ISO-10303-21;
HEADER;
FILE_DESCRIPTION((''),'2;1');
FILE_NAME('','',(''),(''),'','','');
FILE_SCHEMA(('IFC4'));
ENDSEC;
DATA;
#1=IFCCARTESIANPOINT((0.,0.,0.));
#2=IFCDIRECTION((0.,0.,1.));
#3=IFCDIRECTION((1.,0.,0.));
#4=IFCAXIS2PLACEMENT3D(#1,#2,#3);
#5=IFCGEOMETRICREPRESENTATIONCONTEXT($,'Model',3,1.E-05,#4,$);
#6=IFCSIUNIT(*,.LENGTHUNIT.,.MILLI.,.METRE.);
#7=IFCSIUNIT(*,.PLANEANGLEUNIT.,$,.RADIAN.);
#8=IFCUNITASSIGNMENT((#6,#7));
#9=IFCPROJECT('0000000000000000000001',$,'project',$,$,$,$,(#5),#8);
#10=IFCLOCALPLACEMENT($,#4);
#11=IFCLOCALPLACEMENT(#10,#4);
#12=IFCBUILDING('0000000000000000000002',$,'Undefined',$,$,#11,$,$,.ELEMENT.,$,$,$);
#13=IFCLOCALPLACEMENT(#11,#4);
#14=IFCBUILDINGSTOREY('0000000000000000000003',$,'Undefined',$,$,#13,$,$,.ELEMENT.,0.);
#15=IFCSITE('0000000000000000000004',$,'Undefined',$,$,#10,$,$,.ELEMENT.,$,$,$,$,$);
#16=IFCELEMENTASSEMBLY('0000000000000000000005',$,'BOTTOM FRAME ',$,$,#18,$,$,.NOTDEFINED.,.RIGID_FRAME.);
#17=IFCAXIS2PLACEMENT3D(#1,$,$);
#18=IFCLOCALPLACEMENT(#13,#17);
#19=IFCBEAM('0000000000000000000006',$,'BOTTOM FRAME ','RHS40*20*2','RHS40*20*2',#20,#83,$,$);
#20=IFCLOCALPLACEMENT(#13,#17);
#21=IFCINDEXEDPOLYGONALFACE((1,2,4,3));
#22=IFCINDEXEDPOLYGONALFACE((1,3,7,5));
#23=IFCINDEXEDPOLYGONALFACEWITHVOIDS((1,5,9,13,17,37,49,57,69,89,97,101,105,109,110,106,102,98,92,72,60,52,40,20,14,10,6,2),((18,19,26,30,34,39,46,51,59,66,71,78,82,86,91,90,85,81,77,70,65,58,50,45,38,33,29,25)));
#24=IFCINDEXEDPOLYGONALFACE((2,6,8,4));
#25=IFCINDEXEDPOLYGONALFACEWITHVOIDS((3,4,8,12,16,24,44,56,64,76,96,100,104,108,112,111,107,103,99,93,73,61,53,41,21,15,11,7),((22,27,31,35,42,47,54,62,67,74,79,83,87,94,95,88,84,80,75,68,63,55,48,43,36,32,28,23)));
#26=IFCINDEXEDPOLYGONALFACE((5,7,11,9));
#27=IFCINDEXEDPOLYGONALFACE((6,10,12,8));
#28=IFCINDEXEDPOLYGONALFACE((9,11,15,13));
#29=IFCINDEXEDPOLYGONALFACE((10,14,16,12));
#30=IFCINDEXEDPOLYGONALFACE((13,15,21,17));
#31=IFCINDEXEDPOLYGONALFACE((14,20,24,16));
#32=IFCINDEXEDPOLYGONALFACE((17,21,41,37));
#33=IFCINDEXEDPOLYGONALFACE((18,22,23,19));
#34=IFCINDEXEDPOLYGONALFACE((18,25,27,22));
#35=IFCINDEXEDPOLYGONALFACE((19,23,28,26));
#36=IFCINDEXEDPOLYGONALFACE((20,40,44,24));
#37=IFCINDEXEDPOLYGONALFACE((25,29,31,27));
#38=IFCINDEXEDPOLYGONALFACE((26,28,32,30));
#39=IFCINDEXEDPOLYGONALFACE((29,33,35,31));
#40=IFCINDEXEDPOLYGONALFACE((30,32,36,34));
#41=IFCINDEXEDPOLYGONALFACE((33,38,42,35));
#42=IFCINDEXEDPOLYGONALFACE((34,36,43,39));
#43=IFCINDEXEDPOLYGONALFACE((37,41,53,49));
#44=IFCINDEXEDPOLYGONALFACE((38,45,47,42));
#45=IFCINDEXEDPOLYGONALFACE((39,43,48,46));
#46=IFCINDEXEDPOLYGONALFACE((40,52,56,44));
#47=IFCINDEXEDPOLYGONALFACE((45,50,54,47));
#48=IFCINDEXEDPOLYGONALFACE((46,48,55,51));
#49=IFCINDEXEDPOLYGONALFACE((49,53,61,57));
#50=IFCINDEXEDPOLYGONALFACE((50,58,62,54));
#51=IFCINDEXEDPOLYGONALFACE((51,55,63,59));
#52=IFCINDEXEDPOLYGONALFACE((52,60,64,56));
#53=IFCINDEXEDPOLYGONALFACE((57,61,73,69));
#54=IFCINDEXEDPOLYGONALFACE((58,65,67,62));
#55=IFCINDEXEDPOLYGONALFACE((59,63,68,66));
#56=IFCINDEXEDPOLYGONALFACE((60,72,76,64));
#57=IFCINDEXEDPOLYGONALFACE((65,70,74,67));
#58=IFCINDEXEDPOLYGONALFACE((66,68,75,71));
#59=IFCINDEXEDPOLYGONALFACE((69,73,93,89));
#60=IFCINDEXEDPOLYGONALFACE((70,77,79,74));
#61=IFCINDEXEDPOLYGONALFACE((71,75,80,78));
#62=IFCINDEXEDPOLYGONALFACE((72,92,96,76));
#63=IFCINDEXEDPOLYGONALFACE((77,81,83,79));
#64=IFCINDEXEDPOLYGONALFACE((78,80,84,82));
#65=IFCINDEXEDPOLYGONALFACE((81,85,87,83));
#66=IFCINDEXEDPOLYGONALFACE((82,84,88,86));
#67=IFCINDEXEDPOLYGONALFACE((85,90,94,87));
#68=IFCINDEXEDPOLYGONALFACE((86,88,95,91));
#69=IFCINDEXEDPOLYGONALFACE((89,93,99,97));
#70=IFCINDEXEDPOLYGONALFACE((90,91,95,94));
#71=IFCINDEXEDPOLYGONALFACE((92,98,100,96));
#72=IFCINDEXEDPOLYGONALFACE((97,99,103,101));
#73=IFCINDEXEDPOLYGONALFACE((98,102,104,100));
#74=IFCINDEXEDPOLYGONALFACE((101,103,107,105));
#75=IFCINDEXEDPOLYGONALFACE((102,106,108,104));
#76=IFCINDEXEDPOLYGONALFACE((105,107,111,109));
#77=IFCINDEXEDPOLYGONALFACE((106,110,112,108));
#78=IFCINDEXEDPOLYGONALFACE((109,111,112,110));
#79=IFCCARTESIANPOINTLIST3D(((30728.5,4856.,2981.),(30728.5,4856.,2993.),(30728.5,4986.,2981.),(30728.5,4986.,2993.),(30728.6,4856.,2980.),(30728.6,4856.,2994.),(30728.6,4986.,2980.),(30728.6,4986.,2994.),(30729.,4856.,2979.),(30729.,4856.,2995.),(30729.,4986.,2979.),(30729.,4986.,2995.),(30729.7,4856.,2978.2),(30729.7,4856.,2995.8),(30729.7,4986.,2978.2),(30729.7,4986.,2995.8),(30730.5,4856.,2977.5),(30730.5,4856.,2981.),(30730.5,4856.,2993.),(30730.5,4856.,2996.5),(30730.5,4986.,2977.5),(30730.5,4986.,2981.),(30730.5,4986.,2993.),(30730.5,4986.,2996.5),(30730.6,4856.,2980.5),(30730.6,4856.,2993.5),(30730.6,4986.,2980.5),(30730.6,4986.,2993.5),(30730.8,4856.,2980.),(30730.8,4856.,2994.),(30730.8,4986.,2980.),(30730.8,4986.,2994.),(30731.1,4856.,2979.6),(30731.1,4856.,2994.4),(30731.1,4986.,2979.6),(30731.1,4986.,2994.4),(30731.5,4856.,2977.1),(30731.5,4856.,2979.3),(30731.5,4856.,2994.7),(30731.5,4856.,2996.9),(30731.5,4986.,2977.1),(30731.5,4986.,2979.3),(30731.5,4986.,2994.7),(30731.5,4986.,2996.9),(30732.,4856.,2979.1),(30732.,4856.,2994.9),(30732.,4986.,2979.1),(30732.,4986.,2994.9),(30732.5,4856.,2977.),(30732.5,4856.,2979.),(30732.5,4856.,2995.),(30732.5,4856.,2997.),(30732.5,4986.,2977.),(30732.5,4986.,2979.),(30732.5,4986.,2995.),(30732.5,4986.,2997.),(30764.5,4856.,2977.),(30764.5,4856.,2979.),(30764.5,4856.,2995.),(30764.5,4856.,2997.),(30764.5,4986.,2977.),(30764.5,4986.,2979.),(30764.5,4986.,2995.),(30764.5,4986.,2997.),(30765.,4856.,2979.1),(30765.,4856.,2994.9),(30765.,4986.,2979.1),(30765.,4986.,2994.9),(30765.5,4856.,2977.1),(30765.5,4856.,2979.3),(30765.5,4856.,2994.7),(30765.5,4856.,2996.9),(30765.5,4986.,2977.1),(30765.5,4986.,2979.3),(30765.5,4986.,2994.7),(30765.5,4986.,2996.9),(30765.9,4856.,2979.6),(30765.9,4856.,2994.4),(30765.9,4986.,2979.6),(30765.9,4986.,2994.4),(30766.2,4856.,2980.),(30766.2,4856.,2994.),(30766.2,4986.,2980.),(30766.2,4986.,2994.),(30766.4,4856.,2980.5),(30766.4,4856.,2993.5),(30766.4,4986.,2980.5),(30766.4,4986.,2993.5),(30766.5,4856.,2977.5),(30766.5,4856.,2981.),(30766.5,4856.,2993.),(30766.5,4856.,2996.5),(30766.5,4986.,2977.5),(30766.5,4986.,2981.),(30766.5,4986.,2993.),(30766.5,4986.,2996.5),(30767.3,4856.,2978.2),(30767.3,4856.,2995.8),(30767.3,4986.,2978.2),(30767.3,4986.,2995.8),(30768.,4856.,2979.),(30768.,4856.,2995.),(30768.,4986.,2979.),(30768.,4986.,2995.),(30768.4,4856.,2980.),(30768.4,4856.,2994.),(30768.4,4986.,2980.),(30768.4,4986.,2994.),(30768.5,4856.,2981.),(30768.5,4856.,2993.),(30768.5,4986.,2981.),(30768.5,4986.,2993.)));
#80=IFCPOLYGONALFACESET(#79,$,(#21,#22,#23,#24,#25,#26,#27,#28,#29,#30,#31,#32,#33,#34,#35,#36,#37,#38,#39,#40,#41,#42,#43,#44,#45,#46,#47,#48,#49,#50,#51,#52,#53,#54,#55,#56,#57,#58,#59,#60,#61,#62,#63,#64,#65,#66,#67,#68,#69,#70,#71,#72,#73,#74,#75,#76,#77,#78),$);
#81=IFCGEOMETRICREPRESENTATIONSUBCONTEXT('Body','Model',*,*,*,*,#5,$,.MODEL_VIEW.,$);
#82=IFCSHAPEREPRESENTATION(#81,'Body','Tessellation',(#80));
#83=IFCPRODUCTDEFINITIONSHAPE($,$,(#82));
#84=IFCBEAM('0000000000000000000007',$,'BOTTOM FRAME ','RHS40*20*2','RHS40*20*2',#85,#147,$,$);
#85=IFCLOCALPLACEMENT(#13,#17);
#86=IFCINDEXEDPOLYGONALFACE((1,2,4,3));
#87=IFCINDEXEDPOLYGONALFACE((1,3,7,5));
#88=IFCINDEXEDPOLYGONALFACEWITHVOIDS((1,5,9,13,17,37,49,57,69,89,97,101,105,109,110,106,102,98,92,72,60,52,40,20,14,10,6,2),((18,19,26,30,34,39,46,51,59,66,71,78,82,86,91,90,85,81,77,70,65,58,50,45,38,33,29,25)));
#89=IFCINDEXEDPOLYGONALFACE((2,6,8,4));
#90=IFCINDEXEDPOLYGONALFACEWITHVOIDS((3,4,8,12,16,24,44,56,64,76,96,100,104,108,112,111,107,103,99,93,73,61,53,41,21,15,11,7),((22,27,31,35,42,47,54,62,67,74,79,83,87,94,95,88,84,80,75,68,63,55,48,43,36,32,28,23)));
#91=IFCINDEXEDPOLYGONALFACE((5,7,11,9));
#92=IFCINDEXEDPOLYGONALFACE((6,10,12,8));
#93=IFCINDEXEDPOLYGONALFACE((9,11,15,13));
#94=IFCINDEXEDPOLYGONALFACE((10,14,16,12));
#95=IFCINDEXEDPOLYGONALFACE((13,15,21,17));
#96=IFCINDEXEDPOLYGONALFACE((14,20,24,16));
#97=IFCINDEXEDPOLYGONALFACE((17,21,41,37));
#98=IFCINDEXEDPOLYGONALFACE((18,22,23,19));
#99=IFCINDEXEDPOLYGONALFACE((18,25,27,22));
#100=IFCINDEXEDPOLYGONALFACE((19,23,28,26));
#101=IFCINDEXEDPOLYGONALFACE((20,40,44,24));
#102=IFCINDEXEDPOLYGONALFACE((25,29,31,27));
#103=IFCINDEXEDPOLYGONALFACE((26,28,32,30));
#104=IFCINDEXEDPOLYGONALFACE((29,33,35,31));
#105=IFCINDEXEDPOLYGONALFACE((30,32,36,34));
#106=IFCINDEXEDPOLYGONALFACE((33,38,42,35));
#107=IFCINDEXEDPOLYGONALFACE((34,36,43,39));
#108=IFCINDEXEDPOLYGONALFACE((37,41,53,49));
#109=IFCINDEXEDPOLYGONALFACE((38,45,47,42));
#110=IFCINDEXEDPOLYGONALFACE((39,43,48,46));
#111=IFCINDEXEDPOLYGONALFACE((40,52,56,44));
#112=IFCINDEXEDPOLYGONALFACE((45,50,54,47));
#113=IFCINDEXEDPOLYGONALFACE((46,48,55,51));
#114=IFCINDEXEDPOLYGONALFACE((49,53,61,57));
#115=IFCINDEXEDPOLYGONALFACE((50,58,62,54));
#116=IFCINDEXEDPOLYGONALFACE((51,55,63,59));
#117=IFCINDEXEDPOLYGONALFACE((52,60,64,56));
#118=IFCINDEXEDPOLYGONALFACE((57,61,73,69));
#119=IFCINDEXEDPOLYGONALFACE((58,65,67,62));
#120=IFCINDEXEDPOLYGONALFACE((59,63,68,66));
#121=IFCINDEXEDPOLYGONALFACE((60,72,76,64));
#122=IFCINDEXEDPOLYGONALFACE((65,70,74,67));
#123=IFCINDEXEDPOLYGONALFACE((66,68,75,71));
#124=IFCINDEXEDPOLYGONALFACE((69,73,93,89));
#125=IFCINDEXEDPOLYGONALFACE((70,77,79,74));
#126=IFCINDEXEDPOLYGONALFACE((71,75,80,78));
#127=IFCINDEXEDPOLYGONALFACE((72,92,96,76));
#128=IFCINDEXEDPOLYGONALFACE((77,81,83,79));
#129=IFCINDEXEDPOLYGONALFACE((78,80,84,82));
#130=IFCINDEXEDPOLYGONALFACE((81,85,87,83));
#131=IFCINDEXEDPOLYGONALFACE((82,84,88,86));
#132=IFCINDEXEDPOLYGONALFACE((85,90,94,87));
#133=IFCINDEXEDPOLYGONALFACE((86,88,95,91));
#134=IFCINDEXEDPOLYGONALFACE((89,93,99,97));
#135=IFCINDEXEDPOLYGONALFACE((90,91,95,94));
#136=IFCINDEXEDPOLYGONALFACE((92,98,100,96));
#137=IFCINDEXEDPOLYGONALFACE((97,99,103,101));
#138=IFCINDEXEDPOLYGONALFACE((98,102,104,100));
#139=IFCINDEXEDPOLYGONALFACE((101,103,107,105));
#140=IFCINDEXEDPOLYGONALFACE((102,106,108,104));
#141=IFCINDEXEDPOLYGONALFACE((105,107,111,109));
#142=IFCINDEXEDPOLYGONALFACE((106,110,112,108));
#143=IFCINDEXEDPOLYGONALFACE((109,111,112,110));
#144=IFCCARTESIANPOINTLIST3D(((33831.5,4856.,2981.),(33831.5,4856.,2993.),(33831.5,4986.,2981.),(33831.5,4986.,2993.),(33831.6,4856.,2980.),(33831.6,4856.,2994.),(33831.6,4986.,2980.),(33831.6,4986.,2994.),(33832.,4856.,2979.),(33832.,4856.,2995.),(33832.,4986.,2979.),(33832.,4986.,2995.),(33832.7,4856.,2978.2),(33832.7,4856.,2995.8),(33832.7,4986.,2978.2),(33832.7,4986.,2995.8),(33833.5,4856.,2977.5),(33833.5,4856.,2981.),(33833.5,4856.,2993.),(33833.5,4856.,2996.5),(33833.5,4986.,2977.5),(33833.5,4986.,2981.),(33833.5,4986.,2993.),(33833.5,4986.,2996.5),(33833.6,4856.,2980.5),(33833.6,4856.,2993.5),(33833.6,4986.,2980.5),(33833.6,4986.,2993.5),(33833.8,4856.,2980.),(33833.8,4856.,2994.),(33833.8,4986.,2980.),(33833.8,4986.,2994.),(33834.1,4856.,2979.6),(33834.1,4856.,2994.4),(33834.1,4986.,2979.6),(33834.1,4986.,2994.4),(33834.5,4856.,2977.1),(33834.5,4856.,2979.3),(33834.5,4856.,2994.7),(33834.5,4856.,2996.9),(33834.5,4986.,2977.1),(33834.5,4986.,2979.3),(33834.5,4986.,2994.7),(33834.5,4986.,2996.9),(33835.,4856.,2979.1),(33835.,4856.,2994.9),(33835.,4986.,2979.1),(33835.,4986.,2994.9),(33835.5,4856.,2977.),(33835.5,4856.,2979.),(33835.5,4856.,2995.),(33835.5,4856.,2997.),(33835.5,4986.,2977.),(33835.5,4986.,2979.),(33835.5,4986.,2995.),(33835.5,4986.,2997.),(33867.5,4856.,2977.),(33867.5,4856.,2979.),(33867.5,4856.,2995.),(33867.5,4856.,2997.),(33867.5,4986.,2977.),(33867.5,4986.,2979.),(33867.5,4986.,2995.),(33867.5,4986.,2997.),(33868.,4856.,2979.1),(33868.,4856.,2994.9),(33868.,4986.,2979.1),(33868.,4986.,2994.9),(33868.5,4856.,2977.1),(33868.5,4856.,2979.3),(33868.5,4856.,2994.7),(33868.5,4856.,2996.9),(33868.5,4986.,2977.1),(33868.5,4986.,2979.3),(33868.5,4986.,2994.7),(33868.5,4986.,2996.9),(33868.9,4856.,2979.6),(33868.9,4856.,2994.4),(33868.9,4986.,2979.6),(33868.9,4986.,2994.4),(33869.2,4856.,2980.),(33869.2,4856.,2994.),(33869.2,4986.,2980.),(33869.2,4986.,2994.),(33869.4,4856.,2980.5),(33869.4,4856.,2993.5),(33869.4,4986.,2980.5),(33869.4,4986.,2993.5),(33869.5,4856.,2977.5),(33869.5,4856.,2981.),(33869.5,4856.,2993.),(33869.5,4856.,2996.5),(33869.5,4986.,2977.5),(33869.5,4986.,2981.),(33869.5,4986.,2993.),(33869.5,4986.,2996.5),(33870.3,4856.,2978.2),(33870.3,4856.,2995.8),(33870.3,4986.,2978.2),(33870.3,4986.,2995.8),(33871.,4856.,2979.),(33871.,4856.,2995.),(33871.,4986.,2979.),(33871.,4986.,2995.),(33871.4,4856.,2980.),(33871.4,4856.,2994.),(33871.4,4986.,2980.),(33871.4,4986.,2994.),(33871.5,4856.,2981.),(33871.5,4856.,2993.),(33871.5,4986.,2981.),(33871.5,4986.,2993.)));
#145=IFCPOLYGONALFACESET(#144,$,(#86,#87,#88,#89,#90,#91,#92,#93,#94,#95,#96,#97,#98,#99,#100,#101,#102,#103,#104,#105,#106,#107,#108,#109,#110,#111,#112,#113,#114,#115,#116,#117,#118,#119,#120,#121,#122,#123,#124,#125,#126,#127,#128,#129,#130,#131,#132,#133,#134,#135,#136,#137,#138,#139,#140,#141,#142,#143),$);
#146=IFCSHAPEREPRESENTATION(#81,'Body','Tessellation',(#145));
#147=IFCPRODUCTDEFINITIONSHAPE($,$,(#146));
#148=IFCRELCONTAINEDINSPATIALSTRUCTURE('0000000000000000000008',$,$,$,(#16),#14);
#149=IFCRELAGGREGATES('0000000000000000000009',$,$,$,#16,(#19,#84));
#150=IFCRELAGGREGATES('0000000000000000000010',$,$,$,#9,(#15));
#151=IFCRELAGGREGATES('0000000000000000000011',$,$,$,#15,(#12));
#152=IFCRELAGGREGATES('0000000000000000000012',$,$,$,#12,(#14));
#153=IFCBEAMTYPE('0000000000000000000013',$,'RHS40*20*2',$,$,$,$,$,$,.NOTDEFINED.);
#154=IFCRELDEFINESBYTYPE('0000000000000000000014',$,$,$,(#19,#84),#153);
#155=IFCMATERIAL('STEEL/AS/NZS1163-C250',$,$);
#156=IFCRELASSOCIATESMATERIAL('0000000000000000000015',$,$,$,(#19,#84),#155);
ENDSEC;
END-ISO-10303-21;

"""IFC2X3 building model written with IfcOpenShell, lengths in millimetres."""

from ifc_helpers import new_model, si_unit, frame, origin_with_axes, origin_2d_with_axis, place, context, subcontext, project, spatial, hollow_rectangle, extrude, material, type_object, element, aggregate, save


model = new_model("IFC2X3")

# Units and contexts
model_context = context("Model", 3, precision=1e-05, world=origin_with_axes())
body_context = subcontext(model_context, "Body", "Model", "MODEL_VIEW")
ifc_project = project(units=[si_unit("LENGTHUNIT", "METRE", prefix="MILLI"), si_unit("PLANEANGLEUNIT", "RADIAN")], contexts=[model_context])

# Site, building, storey
site_placement = place(None, origin_with_axes())
site = spatial("IfcSite", under=ifc_project, at=site_placement, Name="Undefined", CompositionType="ELEMENT")
building_placement = place(site_placement, origin_with_axes())
building = spatial("IfcBuilding", under=site, at=building_placement, Name="Undefined", CompositionType="ELEMENT")
storey_placement = place(building_placement, origin_with_axes())
storey = spatial("IfcBuildingStorey", under=building, at=storey_placement, Name="Undefined", CompositionType="ELEMENT", Elevation=0.0)

# Element assembly, beams
assembly_1_placement = place(storey_placement, origin_with_axes())
assembly_1 = element("IfcElementAssembly", 1, at=assembly_1_placement, inside=storey, Name="BOTTOM FRAME ", AssemblyPlace="NOTDEFINED", PredefinedType="RIGID_FRAME")
ifc_material_1 = material(Name="STEEL/AS/NZS1163-C250")
beam_type_1 = type_object("IfcBeamType", Name="RHS40*20*2", PredefinedType="NOTDEFINED")
beam_1_placement = place(assembly_1_placement, frame((30748.5, 4986.0, 2987.0), z_axis=(1.0, 0.0, 0.0), x_axis=(0.0, -1.0, 0.0)))
beam_1 = element("IfcBeam", 2, at=beam_1_placement, type_object=beam_type_1, material=ifc_material_1, Name="BOTTOM FRAME ", Description="RHS40*20*2", ObjectType="RHS40*20*2", context=body_context, shape_type="SweptSolid", body=[
    extrude(hollow_rectangle(XDim=20.0, YDim=40.0, WallThickness=2.0, InnerFilletRadius=2.0, OuterFilletRadius=4.0, at=origin_2d_with_axis()), frame((130.0, 0.0, 0.0), z_axis=(-1.0, 0.0, 0.0), x_axis=(0.0, -1.0, 0.0)), (0.0, 0.0, 1.0), 130.0),
])
beam_2_placement = place(assembly_1_placement, frame((33851.5, 4986.0, 2987.0), z_axis=(-1.0, 0.0, 0.0), x_axis=(0.0, -1.0, 0.0)))
beam_2 = element("IfcBeam", 3, at=beam_2_placement, type_object=beam_type_1, material=ifc_material_1, Name="BOTTOM FRAME ", Description="RHS40*20*2", ObjectType="RHS40*20*2", context=body_context, shape_type="SweptSolid", body=[
    extrude(hollow_rectangle(XDim=20.0, YDim=40.0, WallThickness=2.0, InnerFilletRadius=2.0, OuterFilletRadius=4.0, at=origin_2d_with_axis()), frame((130.0, 0.0, 0.0), z_axis=(-1.0, 0.0, 0.0), x_axis=(0.0, -1.0, 0.0)), (0.0, 0.0, 1.0), 130.0),
])
aggregate(assembly_1, [beam_1, beam_2])

save(model, "model.ifc")
